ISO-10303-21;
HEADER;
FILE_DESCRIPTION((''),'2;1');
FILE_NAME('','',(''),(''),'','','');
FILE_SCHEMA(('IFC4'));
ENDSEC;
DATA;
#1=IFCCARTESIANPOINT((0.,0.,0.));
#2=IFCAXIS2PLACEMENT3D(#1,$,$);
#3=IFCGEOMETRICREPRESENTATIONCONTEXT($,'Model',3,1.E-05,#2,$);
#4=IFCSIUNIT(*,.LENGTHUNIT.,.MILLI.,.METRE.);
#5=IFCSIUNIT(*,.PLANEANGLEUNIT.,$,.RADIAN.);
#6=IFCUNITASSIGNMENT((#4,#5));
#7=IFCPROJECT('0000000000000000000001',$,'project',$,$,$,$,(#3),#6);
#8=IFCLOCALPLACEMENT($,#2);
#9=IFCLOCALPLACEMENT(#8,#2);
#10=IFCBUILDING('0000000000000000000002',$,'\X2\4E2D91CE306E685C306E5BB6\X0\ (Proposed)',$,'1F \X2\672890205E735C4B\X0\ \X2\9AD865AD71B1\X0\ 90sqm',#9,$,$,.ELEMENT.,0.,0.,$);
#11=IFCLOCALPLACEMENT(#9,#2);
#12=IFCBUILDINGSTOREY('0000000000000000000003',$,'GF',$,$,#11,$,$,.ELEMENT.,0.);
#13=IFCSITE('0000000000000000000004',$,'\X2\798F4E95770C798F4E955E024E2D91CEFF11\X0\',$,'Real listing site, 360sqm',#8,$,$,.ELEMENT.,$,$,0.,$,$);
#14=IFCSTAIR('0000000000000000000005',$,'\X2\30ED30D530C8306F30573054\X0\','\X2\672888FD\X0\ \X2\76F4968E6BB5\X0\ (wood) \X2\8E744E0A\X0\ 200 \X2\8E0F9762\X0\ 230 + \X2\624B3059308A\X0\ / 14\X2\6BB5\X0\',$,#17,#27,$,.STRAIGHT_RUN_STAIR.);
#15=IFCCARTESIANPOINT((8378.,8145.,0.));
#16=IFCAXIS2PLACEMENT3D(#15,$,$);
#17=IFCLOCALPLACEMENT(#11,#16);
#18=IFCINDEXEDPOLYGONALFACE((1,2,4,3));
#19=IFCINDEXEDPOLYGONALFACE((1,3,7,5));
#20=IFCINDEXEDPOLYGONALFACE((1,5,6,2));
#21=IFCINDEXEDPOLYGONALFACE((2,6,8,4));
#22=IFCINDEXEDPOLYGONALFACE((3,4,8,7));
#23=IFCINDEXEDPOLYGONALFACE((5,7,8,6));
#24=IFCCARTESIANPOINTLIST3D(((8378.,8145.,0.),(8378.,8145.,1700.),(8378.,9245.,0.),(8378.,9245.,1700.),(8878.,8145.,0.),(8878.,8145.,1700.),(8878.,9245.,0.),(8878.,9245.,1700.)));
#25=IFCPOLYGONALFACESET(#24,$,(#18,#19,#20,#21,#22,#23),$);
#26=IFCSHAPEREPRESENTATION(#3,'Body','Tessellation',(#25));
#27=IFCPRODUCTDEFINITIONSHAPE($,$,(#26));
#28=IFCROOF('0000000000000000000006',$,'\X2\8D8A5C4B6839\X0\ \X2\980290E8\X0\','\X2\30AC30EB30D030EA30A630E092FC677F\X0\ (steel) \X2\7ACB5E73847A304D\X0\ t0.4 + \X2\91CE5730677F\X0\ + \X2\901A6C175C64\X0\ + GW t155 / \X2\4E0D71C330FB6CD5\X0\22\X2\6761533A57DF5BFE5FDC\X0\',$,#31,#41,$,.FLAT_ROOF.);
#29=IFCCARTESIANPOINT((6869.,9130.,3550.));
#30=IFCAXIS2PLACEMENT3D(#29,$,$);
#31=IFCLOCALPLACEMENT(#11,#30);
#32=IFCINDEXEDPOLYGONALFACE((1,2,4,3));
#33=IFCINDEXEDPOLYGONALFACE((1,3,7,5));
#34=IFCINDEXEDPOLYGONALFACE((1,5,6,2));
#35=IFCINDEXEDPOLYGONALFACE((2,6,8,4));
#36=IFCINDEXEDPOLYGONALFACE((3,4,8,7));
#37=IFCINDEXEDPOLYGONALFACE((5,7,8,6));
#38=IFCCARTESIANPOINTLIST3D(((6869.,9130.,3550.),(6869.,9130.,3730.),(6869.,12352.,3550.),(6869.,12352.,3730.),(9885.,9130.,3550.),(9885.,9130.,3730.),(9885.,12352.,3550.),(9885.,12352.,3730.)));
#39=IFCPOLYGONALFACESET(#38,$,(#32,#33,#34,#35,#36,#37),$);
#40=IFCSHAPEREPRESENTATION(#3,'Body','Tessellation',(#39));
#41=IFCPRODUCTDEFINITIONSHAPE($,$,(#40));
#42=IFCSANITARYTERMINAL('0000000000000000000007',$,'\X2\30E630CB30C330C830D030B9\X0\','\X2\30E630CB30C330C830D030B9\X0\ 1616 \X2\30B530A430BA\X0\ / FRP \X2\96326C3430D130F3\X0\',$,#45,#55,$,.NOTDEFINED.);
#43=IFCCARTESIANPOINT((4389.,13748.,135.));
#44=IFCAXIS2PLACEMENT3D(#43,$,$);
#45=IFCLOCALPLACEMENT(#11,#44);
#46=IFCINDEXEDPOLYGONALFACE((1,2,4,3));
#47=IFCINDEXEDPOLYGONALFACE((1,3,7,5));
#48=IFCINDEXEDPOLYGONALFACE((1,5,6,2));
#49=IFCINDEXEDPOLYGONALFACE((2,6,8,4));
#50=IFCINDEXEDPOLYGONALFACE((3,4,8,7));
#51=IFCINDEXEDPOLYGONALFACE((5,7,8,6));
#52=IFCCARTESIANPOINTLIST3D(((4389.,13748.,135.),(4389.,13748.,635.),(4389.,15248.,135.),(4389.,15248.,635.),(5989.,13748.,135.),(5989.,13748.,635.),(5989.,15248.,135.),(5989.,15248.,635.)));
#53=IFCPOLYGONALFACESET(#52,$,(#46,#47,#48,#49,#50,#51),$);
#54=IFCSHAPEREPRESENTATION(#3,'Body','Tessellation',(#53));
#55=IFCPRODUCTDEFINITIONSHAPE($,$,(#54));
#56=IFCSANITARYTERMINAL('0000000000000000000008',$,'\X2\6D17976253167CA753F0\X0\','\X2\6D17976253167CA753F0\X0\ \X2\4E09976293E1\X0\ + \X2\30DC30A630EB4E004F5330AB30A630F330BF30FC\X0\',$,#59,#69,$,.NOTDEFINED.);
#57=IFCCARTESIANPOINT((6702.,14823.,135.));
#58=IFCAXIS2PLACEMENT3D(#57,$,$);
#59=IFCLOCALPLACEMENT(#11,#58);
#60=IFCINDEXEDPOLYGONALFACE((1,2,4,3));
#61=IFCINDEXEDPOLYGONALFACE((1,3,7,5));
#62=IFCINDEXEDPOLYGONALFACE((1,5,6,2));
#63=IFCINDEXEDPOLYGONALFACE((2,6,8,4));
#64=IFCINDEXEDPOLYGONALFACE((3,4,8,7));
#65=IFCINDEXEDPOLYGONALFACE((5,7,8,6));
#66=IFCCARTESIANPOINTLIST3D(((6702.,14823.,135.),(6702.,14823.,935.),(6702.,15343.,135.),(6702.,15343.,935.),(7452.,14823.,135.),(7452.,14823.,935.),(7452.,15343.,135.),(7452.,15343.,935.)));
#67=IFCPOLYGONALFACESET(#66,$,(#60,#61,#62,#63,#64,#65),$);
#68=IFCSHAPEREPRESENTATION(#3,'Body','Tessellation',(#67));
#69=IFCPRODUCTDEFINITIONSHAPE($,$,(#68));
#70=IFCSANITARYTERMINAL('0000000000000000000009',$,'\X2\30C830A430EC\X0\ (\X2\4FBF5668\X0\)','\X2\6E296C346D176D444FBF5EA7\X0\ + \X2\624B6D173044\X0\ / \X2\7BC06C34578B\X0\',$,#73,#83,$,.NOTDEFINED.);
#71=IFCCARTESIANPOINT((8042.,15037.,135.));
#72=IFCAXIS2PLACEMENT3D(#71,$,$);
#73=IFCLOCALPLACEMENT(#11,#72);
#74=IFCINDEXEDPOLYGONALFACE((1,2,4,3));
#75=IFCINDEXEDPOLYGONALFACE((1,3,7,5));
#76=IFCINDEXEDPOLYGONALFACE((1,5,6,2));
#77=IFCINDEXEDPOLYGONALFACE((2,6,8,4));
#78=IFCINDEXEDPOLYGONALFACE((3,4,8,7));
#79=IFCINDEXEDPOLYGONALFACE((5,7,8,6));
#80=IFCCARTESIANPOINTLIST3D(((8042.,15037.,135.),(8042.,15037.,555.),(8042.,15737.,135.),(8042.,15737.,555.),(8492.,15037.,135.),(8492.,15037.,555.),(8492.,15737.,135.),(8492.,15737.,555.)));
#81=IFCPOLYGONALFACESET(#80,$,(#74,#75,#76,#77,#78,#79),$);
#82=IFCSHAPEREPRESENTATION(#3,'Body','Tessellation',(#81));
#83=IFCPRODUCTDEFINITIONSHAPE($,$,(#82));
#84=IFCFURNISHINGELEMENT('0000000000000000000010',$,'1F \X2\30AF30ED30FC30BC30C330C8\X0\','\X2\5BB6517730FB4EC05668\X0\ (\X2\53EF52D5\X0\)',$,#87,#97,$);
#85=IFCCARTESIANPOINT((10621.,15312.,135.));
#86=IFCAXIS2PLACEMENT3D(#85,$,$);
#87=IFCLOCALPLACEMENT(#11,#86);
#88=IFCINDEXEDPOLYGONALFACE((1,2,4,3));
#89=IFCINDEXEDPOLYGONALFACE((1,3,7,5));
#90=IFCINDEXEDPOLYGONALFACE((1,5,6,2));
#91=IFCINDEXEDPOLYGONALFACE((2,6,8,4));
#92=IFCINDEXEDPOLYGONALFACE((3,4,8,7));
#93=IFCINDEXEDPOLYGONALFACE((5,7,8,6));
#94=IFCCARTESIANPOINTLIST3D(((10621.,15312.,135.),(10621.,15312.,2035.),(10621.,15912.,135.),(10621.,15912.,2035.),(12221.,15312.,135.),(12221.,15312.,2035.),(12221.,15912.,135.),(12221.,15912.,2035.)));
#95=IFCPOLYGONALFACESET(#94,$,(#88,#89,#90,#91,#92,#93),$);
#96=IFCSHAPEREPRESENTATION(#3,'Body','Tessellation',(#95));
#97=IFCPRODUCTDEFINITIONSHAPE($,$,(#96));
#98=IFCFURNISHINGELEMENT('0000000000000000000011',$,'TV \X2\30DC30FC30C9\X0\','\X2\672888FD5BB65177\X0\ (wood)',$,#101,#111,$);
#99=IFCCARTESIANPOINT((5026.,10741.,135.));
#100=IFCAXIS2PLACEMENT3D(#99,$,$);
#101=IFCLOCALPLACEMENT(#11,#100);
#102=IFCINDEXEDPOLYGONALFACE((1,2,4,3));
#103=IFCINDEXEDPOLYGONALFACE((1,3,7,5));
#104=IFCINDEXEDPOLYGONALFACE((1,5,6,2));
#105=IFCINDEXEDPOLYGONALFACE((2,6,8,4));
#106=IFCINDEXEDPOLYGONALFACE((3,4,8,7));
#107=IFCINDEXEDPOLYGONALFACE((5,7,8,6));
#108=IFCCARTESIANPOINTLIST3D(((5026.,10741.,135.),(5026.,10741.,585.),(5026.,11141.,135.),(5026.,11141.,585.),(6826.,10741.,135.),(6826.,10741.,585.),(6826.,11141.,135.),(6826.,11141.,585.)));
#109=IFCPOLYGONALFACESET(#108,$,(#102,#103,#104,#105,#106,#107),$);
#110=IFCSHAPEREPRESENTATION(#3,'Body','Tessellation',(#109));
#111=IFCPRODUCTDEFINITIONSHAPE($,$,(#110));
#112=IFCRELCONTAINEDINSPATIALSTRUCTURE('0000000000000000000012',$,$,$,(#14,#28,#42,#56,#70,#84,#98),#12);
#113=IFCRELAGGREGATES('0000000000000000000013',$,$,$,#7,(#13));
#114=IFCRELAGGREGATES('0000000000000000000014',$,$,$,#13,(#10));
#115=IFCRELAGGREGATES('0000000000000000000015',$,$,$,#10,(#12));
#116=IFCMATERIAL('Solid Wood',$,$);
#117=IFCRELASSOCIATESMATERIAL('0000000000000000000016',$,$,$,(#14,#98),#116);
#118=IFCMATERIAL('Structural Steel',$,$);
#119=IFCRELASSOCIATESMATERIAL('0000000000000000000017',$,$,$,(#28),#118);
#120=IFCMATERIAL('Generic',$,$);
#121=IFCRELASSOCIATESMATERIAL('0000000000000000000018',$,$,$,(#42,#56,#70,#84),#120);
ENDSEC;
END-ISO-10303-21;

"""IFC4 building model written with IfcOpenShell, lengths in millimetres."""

from ifc_helpers import new_model, si_unit, frame, frame_2d, origin, place, context, project, spatial, rectangle, extrude, material, element, save


model = new_model("IFC4")

# Units and contexts
model_context = context("Model", 3, precision=1e-05, world=origin())
ifc_project = project(units=[si_unit("LENGTHUNIT", "METRE", prefix="MILLI"), si_unit("PLANEANGLEUNIT", "RADIAN")], contexts=[model_context])

# Site, building, storey
site_placement = place(None, origin())
site = spatial("IfcSite", under=ifc_project, at=site_placement, Name="福井県福井市中野１", ObjectType="Real listing site, 360sqm", CompositionType="ELEMENT", RefElevation=0.0)
building_placement = place(site_placement, origin())
building = spatial("IfcBuilding", under=site, at=building_placement, Name="中野の桜の家 (Proposed)", ObjectType="1F 木造平屋 高断熱 90sqm", CompositionType="ELEMENT", ElevationOfRefHeight=0.0, ElevationOfTerrain=0.0)
storey_placement = place(building_placement, origin())
storey = spatial("IfcBuildingStorey", under=building, at=storey_placement, Name="GF", CompositionType="ELEMENT", Elevation=0.0)

# Shared definitions
ifc_material_1 = material(Name="Solid Wood")

# Stair
stair_placement = place(storey_placement, frame((8378.0, 8145.0, 0.0)))
element("IfcStair", 1, at=stair_placement, inside=storey, material=ifc_material_1, Name="ロフトはしご", Description="木製 直階段 (wood) 蹴上 200 踏面 230 + 手すり / 14段", PredefinedType="STRAIGHT_RUN_STAIR", context=model_context, shape_type="SweptSolid", body=[
    extrude(rectangle(XDim=500.0, YDim=1100.0, at=frame_2d((250.0, 550.0))), frame((8378.0, 8145.0, 0.0)), (0.0, 0.0, 1.0), 1700.0),
])

# Roof
ifc_material_2 = material(Name="Structural Steel")
roof_placement = place(storey_placement, frame((6869.0, 9130.0, 3550.0)))
element("IfcRoof", 2, at=roof_placement, inside=storey, material=ifc_material_2, Name="越屋根 頂部", Description="ガルバリウム鋼板 (steel) 立平葺き t0.4 + 野地板 + 通気層 + GW t155 / 不燃・法22条区域対応", PredefinedType="FLAT_ROOF", context=model_context, shape_type="SweptSolid", body=[
    extrude(rectangle(XDim=3016.0, YDim=3222.0, at=frame_2d((1508.0, 1611.0))), frame((6869.0, 9130.0, 3550.0)), (0.0, 0.0, 1.0), 180.0),
])

# Sanitary terminals
ifc_material_3 = material(Name="Generic")
sanitary_terminal_1_placement = place(storey_placement, frame((4389.0, 13748.0, 135.0)))
element("IfcSanitaryTerminal", 3, at=sanitary_terminal_1_placement, inside=storey, material=ifc_material_3, Name="ユニットバス", Description="ユニットバス 1616 サイズ / FRP 防水パン", PredefinedType="NOTDEFINED", context=model_context, shape_type="SweptSolid", body=[
    extrude(rectangle(XDim=1600.0, YDim=1500.0, at=frame_2d((800.0, 750.0))), frame((4389.0, 13748.0, 135.0)), (0.0, 0.0, 1.0), 500.0),
])
sanitary_terminal_2_placement = place(storey_placement, frame((6702.0, 14823.0, 135.0)))
element("IfcSanitaryTerminal", 4, at=sanitary_terminal_2_placement, inside=storey, material=ifc_material_3, Name="洗面化粧台", Description="洗面化粧台 三面鏡 + ボウル一体カウンター", PredefinedType="NOTDEFINED", context=model_context, shape_type="SweptSolid", body=[
    extrude(rectangle(XDim=750.0, YDim=520.0, at=frame_2d((375.0, 260.0))), frame((6702.0, 14823.0, 135.0)), (0.0, 0.0, 1.0), 800.0),
])
sanitary_terminal_3_placement = place(storey_placement, frame((8042.0, 15037.0, 135.0)))
element("IfcSanitaryTerminal", 5, at=sanitary_terminal_3_placement, inside=storey, material=ifc_material_3, Name="トイレ (便器)", Description="温水洗浄便座 + 手洗い / 節水型", PredefinedType="NOTDEFINED", context=model_context, shape_type="SweptSolid", body=[
    extrude(rectangle(XDim=450.0, YDim=700.0, at=frame_2d((225.0, 350.0))), frame((8042.0, 15037.0, 135.0)), (0.0, 0.0, 1.0), 420.0),
])

# Furnishing elements
furnishing_1_placement = place(storey_placement, frame((10621.0, 15312.0, 135.0)))
element("IfcFurnishingElement", 6, at=furnishing_1_placement, inside=storey, material=ifc_material_3, Name="1F クローゼット", Description="家具・什器 (可動)", context=model_context, shape_type="SweptSolid", body=[
    extrude(rectangle(XDim=1600.0, YDim=600.0, at=frame_2d((800.0, 300.0))), frame((10621.0, 15312.0, 135.0)), (0.0, 0.0, 1.0), 1900.0),
])
furnishing_2_placement = place(storey_placement, frame((5026.0, 10741.0, 135.0)))
element("IfcFurnishingElement", 7, at=furnishing_2_placement, inside=storey, material=ifc_material_1, Name="TV ボード", Description="木製家具 (wood)", context=model_context, shape_type="SweptSolid", body=[
    extrude(rectangle(XDim=1800.0, YDim=400.0, at=frame_2d((900.0, 200.0))), frame((5026.0, 10741.0, 135.0)), (0.0, 0.0, 1.0), 450.0),
])

save(model, "model.ifc")
